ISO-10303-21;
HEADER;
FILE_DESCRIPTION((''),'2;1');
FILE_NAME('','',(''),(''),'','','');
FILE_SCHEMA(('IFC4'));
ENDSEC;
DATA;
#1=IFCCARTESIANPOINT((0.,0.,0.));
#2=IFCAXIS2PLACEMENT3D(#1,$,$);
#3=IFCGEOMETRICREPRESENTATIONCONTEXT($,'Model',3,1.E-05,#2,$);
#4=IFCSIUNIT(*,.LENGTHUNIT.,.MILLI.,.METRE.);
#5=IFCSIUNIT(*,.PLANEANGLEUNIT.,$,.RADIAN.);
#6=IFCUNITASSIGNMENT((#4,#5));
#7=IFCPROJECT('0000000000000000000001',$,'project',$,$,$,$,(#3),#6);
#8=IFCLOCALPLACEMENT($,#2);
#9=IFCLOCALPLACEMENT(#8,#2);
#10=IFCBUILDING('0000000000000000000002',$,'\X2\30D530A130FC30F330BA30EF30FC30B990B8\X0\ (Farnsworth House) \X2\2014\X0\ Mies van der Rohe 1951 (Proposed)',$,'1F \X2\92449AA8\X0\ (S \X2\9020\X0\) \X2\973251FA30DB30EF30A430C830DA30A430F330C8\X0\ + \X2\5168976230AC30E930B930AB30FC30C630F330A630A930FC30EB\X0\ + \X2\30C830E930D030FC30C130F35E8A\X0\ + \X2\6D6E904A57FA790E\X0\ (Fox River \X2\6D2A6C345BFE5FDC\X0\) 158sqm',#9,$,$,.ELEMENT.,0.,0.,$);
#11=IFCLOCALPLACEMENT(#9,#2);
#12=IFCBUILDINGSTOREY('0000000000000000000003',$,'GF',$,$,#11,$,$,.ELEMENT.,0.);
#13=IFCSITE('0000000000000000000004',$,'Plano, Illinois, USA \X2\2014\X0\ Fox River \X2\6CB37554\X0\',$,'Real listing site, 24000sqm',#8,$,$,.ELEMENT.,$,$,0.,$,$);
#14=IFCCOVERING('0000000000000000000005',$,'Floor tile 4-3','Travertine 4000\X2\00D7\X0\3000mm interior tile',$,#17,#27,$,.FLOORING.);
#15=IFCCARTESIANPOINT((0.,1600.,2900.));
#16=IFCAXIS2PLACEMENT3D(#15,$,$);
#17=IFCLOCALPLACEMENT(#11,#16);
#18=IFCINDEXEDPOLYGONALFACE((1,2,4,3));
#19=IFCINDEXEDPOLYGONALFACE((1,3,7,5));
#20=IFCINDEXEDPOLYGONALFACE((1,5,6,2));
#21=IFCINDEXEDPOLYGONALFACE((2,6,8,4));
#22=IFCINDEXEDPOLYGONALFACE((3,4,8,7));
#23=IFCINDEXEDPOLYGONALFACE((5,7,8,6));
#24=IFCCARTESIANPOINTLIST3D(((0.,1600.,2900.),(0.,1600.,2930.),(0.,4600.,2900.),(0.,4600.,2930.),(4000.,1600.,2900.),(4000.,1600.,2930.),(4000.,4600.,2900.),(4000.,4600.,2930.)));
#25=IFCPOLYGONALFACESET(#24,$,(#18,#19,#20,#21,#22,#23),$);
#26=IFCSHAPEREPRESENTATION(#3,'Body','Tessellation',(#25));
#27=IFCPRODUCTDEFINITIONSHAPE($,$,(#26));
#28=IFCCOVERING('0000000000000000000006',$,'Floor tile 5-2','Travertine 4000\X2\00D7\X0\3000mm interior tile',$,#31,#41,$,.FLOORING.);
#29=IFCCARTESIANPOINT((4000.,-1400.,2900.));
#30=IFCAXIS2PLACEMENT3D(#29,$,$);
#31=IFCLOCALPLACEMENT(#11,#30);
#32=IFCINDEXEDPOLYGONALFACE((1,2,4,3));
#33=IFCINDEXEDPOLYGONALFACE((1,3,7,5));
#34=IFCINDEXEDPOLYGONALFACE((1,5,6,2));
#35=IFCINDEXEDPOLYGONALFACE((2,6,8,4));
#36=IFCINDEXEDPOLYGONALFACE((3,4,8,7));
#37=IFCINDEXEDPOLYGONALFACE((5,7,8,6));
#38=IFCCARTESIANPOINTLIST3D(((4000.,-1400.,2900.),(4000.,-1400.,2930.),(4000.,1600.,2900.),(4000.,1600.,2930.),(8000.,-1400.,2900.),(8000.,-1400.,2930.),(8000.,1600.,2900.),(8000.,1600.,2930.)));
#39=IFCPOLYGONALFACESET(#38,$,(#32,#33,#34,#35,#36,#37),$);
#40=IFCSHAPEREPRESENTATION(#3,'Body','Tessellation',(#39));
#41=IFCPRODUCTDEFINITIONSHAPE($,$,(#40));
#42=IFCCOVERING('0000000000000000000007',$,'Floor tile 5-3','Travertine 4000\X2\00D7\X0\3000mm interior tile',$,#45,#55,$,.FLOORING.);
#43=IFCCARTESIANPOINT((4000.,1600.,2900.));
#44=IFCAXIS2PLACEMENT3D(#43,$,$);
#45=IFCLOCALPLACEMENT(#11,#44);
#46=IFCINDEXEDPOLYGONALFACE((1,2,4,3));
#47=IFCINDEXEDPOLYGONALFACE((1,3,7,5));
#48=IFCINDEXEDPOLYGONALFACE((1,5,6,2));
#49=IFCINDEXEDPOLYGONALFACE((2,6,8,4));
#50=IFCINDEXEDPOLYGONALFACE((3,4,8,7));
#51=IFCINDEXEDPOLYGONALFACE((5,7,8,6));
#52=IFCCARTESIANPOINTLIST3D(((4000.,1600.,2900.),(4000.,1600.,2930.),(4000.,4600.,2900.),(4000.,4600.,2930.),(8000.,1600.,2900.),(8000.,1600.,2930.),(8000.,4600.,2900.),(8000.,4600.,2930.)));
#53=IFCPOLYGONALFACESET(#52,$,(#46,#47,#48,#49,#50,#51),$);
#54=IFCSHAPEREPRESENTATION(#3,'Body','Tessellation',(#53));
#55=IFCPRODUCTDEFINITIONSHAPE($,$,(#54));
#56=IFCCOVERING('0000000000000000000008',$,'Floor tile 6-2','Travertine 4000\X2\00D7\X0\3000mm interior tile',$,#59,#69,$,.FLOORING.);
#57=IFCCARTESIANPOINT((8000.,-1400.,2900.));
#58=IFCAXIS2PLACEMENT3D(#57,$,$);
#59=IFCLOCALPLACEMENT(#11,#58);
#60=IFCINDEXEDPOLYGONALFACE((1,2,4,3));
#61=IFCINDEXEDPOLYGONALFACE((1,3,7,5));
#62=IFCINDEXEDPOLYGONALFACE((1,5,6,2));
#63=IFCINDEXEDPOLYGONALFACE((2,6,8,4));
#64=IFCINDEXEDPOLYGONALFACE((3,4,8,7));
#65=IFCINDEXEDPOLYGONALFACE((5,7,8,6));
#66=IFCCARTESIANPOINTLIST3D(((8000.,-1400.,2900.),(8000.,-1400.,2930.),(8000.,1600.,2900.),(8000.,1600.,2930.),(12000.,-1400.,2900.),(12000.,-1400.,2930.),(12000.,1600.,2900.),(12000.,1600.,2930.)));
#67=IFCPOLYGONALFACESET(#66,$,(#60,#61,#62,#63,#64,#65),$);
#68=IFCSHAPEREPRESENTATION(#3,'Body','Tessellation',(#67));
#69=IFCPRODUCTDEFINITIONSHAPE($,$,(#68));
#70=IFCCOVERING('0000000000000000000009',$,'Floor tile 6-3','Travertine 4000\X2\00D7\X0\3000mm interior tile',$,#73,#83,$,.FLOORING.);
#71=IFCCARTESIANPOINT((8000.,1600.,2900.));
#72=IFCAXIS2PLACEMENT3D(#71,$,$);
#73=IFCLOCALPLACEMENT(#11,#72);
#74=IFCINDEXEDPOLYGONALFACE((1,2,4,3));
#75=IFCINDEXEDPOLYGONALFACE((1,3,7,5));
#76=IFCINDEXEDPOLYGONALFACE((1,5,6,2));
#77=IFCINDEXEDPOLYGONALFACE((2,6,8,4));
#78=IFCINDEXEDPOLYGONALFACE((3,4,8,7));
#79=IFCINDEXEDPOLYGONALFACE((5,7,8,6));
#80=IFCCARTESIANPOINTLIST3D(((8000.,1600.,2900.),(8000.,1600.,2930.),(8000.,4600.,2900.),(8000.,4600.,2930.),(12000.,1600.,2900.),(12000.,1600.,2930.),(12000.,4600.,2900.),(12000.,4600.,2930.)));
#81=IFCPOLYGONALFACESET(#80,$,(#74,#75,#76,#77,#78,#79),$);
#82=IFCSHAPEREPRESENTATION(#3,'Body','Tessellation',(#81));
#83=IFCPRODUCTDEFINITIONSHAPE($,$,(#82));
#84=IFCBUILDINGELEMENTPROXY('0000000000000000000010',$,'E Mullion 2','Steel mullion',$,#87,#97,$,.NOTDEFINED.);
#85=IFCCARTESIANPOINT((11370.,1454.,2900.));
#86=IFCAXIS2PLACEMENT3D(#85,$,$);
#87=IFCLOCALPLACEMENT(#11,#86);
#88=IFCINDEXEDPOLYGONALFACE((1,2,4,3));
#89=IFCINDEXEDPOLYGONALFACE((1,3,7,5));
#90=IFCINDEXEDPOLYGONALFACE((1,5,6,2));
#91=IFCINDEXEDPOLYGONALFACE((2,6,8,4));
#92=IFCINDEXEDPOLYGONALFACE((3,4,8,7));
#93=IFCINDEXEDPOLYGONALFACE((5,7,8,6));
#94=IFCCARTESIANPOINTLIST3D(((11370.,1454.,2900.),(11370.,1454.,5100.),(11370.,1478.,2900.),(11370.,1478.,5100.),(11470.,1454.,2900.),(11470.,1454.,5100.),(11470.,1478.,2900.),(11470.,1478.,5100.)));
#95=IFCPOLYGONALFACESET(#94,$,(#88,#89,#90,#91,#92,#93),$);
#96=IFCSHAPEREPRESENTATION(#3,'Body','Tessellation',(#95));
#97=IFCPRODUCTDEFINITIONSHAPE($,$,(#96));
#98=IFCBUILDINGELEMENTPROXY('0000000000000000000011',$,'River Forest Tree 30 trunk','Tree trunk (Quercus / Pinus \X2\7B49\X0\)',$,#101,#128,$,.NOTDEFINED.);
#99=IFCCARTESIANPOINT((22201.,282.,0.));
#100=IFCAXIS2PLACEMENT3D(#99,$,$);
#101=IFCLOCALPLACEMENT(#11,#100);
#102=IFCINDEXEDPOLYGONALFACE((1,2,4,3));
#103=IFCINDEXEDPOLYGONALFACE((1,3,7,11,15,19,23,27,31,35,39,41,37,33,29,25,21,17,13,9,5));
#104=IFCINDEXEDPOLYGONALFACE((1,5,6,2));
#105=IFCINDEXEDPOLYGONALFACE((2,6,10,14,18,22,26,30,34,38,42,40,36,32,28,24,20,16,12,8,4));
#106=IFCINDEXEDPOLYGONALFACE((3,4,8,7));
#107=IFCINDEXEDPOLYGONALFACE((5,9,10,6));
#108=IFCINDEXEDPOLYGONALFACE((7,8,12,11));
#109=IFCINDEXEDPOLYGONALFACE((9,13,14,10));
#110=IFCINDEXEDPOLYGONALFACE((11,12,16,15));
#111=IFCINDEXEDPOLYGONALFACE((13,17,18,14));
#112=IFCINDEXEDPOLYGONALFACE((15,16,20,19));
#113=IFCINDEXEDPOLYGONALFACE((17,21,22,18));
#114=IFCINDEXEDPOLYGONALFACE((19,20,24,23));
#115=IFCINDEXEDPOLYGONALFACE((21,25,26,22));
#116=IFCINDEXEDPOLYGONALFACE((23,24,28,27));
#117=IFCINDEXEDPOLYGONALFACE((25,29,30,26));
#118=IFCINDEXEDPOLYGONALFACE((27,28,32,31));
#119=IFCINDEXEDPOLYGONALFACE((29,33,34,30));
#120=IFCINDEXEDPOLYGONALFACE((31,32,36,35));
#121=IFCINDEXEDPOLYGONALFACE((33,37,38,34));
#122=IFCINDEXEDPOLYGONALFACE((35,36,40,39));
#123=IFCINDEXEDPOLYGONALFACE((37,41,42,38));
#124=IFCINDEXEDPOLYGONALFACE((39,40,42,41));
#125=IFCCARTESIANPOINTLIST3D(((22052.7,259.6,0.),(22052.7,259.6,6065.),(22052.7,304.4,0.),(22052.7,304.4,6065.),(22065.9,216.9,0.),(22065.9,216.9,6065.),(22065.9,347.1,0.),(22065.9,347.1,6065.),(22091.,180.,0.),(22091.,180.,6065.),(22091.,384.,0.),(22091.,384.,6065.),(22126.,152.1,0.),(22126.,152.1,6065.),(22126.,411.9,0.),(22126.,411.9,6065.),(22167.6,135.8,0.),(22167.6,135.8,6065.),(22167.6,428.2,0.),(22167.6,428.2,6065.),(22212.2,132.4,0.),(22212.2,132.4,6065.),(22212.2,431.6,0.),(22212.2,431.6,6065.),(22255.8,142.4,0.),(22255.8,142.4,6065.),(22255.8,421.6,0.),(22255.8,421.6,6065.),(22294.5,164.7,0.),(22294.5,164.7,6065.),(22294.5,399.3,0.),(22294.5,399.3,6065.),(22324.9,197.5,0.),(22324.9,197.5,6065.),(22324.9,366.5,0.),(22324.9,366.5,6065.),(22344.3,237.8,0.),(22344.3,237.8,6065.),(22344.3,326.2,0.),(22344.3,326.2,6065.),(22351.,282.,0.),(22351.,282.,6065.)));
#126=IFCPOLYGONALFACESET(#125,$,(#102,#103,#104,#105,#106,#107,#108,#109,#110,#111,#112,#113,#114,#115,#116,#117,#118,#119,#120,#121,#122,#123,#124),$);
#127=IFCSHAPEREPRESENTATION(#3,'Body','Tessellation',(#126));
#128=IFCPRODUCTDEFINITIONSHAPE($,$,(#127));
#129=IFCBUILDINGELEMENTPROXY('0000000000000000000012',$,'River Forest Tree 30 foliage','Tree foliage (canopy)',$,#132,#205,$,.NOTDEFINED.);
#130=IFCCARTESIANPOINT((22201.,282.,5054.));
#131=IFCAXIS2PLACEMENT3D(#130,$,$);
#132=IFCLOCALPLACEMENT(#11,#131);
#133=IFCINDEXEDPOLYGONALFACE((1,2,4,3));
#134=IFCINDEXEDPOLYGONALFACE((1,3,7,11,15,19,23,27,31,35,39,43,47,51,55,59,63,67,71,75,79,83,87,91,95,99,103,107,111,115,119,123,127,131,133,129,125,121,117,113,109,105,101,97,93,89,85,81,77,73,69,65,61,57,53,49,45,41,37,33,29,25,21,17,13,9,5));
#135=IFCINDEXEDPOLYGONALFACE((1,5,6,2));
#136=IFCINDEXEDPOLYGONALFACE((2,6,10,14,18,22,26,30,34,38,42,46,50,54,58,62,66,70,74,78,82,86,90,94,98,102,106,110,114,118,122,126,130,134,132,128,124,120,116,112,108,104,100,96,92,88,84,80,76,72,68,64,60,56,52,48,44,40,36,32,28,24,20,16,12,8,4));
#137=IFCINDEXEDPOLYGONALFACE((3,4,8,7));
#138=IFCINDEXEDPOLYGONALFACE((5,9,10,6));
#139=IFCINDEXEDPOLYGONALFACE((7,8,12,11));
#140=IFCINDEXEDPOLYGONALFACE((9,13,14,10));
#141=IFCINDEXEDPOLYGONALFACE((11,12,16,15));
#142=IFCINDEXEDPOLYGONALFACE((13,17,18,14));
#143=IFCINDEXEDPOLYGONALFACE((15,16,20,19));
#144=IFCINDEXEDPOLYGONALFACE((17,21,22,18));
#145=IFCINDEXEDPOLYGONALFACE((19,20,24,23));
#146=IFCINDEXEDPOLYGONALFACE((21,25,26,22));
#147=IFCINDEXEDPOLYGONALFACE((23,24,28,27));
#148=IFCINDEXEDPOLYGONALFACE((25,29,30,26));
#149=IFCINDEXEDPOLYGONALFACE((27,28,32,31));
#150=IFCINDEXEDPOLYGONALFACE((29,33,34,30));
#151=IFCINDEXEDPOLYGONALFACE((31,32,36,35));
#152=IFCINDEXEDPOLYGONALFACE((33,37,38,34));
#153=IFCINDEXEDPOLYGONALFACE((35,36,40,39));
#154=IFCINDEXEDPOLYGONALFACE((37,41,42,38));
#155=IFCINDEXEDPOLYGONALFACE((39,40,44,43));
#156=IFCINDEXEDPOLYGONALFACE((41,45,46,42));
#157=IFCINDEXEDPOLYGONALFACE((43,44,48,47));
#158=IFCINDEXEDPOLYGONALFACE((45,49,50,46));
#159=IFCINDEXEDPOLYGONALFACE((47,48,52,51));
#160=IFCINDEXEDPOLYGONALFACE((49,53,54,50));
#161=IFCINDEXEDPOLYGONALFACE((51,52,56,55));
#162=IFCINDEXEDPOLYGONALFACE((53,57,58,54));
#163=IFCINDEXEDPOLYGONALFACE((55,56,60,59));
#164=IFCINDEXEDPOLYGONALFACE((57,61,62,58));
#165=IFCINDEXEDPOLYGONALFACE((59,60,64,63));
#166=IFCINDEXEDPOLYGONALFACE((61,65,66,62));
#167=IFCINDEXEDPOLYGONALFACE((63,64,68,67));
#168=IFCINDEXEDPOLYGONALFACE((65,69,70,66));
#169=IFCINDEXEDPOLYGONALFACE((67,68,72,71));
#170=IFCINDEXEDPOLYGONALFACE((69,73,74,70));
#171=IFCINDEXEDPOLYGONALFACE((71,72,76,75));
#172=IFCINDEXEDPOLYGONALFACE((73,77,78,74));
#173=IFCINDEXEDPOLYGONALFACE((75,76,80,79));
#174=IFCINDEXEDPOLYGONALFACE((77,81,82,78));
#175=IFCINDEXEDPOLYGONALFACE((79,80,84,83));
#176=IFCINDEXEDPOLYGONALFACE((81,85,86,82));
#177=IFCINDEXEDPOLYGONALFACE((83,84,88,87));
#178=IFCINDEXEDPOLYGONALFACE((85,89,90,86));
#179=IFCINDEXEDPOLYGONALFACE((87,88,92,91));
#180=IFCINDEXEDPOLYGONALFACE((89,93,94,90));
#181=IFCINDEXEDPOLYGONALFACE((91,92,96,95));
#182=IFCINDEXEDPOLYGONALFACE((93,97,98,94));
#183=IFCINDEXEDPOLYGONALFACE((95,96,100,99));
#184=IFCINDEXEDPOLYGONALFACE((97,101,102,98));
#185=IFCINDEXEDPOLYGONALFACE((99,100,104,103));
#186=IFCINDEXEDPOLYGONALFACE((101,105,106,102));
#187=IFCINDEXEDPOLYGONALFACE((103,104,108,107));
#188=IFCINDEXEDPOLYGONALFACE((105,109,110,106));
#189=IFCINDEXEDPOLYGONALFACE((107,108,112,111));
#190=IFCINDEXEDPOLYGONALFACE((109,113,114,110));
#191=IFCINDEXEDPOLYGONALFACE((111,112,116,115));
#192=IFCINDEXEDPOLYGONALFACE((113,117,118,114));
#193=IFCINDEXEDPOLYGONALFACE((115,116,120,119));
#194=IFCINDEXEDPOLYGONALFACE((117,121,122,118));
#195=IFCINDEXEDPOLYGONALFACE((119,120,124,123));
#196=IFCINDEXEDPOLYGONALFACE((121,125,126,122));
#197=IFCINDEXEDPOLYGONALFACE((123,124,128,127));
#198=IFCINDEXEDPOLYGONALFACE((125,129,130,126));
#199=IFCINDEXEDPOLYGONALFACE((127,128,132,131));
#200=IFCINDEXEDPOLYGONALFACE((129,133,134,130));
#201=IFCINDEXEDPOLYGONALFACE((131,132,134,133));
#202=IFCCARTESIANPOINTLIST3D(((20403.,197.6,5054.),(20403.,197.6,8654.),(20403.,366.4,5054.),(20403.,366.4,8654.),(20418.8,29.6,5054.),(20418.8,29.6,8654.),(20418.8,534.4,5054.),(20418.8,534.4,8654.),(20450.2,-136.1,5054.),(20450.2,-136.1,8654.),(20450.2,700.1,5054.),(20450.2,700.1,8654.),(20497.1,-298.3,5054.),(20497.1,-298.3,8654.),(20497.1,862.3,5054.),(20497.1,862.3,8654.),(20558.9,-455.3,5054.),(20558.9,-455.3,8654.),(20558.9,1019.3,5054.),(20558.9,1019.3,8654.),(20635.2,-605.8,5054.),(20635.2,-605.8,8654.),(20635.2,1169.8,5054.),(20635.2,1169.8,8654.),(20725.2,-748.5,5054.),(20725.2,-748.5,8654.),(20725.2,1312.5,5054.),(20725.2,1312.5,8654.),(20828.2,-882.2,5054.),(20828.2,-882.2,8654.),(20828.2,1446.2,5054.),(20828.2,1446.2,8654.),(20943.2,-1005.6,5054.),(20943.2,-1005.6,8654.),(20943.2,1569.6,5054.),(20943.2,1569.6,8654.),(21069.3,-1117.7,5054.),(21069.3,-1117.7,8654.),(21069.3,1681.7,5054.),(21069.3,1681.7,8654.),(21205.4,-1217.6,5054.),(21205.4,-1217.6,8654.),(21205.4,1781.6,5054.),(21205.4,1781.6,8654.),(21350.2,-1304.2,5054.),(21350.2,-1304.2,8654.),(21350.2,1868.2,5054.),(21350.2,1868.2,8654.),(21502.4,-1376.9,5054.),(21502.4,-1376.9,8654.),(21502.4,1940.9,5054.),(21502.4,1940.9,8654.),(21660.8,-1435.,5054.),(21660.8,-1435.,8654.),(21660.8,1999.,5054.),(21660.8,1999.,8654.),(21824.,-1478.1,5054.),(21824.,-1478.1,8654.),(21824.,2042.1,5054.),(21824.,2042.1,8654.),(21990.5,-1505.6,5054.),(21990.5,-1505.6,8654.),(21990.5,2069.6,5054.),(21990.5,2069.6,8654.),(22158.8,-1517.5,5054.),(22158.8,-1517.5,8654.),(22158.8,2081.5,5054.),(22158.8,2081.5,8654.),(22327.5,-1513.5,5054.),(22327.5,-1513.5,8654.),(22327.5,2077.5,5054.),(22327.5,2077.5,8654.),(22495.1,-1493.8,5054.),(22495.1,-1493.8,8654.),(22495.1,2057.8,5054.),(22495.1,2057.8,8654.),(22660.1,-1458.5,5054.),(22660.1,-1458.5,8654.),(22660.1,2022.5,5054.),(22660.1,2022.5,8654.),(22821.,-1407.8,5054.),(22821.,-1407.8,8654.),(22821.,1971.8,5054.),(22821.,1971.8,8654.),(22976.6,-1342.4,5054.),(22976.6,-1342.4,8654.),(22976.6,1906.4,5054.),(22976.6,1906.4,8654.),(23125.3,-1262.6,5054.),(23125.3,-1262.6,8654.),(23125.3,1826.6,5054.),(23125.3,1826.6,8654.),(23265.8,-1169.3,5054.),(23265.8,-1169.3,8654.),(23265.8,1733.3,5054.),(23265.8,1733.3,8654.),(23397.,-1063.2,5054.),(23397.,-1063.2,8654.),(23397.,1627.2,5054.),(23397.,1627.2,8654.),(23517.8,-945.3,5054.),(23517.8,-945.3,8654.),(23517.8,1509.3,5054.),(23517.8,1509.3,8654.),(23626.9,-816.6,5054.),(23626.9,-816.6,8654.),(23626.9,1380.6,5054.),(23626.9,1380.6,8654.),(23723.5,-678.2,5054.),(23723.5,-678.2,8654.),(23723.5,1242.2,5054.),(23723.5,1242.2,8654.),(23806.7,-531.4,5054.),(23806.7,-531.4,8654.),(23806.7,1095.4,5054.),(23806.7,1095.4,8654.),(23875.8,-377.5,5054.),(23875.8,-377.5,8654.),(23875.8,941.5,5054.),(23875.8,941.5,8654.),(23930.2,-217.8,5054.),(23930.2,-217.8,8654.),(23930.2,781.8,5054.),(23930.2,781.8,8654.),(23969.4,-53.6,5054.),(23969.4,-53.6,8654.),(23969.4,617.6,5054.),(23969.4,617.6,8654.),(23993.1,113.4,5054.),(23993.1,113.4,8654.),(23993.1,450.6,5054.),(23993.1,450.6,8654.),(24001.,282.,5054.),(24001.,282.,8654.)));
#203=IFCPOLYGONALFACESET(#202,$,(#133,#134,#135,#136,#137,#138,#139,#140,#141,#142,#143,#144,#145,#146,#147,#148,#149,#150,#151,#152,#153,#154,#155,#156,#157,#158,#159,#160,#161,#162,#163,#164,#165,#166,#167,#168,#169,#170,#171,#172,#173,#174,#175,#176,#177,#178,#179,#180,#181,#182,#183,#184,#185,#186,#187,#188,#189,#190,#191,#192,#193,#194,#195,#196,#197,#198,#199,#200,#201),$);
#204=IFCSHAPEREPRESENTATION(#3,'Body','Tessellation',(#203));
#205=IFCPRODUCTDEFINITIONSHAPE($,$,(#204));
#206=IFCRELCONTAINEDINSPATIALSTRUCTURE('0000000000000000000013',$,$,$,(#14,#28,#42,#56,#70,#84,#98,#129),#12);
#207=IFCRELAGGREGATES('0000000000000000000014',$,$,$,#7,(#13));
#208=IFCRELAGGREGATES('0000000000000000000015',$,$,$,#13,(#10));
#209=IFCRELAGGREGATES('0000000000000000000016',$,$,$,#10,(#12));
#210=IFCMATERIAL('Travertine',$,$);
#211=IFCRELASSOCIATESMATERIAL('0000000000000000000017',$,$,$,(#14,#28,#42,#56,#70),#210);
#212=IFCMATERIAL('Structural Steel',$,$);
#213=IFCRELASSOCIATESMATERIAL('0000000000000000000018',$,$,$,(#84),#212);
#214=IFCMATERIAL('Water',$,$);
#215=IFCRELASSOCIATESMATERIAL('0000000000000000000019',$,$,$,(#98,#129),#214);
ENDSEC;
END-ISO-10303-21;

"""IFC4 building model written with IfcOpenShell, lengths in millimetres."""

from ifc_helpers import new_model, si_unit, frame, frame_2d, origin, origin_2d, place, context, project, spatial, rectangle, circle, extrude, material, element, save


model = new_model("IFC4")

# Units and contexts
model_context = context("Model", 3, precision=1e-05, world=origin())
ifc_project = project(units=[si_unit("LENGTHUNIT", "METRE", prefix="MILLI"), si_unit("PLANEANGLEUNIT", "RADIAN")], contexts=[model_context])

# Site, building, storey
site_placement = place(None, origin())
site = spatial("IfcSite", under=ifc_project, at=site_placement, Name="Plano, Illinois, USA — Fox River 河畔", ObjectType="Real listing site, 24000sqm", CompositionType="ELEMENT", RefElevation=0.0)
building_placement = place(site_placement, origin())
building = spatial("IfcBuilding", under=site, at=building_placement, Name="ファーンズワース邸 (Farnsworth House) — Mies van der Rohe 1951 (Proposed)", ObjectType="1F 鉄骨 (S 造) 露出ホワイトペイント + 全面ガラスカーテンウォール + トラバーチン床 + 浮遊基礎 (Fox River 洪水対応) 158sqm", CompositionType="ELEMENT", ElevationOfRefHeight=0.0, ElevationOfTerrain=0.0)
storey_placement = place(building_placement, origin())
storey = spatial("IfcBuildingStorey", under=building, at=storey_placement, Name="GF", CompositionType="ELEMENT", Elevation=0.0)

# Shared definitions
ifc_material_1 = material(Name="Structural Steel")

# Shared definitions
ifc_material_2 = material(Name="Travertine")

# Coverings
covering_1_placement = place(storey_placement, frame((0.0, 1600.0, 2900.0)))
element("IfcCovering", 1, at=covering_1_placement, inside=storey, material=ifc_material_2, Name="Floor tile 4-3", Description="Travertine 4000×3000mm interior tile", PredefinedType="FLOORING", context=model_context, shape_type="SweptSolid", body=[
    extrude(rectangle(XDim=4000.0, YDim=3000.0, at=frame_2d((2000.0, 1500.0))), frame((0.0, 1600.0, 2900.0)), (0.0, 0.0, 1.0), 30.0),
])
covering_2_placement = place(storey_placement, frame((4000.0, -1400.0, 2900.0)))
element("IfcCovering", 2, at=covering_2_placement, inside=storey, material=ifc_material_2, Name="Floor tile 5-2", Description="Travertine 4000×3000mm interior tile", PredefinedType="FLOORING", context=model_context, shape_type="SweptSolid", body=[
    extrude(rectangle(XDim=4000.0, YDim=3000.0, at=frame_2d((2000.0, 1500.0))), frame((4000.0, -1400.0, 2900.0)), (0.0, 0.0, 1.0), 30.0),
])
covering_3_placement = place(storey_placement, frame((4000.0, 1600.0, 2900.0)))
element("IfcCovering", 3, at=covering_3_placement, inside=storey, material=ifc_material_2, Name="Floor tile 5-3", Description="Travertine 4000×3000mm interior tile", PredefinedType="FLOORING", context=model_context, shape_type="SweptSolid", body=[
    extrude(rectangle(XDim=4000.0, YDim=3000.0, at=frame_2d((2000.0, 1500.0))), frame((4000.0, 1600.0, 2900.0)), (0.0, 0.0, 1.0), 30.0),
])
covering_4_placement = place(storey_placement, frame((8000.0, -1400.0, 2900.0)))
element("IfcCovering", 4, at=covering_4_placement, inside=storey, material=ifc_material_2, Name="Floor tile 6-2", Description="Travertine 4000×3000mm interior tile", PredefinedType="FLOORING", context=model_context, shape_type="SweptSolid", body=[
    extrude(rectangle(XDim=4000.0, YDim=3000.0, at=frame_2d((2000.0, 1500.0))), frame((8000.0, -1400.0, 2900.0)), (0.0, 0.0, 1.0), 30.0),
])
covering_5_placement = place(storey_placement, frame((8000.0, 1600.0, 2900.0)))
element("IfcCovering", 5, at=covering_5_placement, inside=storey, material=ifc_material_2, Name="Floor tile 6-3", Description="Travertine 4000×3000mm interior tile", PredefinedType="FLOORING", context=model_context, shape_type="SweptSolid", body=[
    extrude(rectangle(XDim=4000.0, YDim=3000.0, at=frame_2d((2000.0, 1500.0))), frame((8000.0, 1600.0, 2900.0)), (0.0, 0.0, 1.0), 30.0),
])

# Building element proxies
proxy_1_placement = place(storey_placement, frame((11370.0, 1454.0, 2900.0)))
element("IfcBuildingElementProxy", 6, at=proxy_1_placement, inside=storey, material=ifc_material_1, Name="E Mullion 2", Description="Steel mullion", PredefinedType="NOTDEFINED", context=model_context, shape_type="SweptSolid", body=[
    extrude(rectangle(XDim=100.0, YDim=24.0, at=frame_2d((50.0, 12.0))), frame((11370.0, 1454.0, 2900.0)), (0.0, 0.0, 1.0), 2200.0),
])
ifc_material_3 = material(Name="Water")
proxy_2_placement = place(storey_placement, frame((22201.0, 282.0, 0.0)))
element("IfcBuildingElementProxy", 7, at=proxy_2_placement, inside=storey, material=ifc_material_3, Name="River Forest Tree 30 trunk", Description="Tree trunk (Quercus / Pinus 等)", PredefinedType="NOTDEFINED", context=model_context, shape_type="SweptSolid", body=[
    extrude(circle(Radius=150.0, at=origin_2d()), frame((22201.0, 282.0, 0.0)), (0.0, 0.0, 1.0), 6065.0),
])
proxy_3_placement = place(storey_placement, frame((22201.0, 282.0, 5054.0)))
element("IfcBuildingElementProxy", 8, at=proxy_3_placement, inside=storey, material=ifc_material_3, Name="River Forest Tree 30 foliage", Description="Tree foliage (canopy)", PredefinedType="NOTDEFINED", context=model_context, shape_type="SweptSolid", body=[
    extrude(circle(Radius=1800.0, at=origin_2d()), frame((22201.0, 282.0, 5054.0)), (0.0, 0.0, 1.0), 3600.0),
])

save(model, "model.ifc")
